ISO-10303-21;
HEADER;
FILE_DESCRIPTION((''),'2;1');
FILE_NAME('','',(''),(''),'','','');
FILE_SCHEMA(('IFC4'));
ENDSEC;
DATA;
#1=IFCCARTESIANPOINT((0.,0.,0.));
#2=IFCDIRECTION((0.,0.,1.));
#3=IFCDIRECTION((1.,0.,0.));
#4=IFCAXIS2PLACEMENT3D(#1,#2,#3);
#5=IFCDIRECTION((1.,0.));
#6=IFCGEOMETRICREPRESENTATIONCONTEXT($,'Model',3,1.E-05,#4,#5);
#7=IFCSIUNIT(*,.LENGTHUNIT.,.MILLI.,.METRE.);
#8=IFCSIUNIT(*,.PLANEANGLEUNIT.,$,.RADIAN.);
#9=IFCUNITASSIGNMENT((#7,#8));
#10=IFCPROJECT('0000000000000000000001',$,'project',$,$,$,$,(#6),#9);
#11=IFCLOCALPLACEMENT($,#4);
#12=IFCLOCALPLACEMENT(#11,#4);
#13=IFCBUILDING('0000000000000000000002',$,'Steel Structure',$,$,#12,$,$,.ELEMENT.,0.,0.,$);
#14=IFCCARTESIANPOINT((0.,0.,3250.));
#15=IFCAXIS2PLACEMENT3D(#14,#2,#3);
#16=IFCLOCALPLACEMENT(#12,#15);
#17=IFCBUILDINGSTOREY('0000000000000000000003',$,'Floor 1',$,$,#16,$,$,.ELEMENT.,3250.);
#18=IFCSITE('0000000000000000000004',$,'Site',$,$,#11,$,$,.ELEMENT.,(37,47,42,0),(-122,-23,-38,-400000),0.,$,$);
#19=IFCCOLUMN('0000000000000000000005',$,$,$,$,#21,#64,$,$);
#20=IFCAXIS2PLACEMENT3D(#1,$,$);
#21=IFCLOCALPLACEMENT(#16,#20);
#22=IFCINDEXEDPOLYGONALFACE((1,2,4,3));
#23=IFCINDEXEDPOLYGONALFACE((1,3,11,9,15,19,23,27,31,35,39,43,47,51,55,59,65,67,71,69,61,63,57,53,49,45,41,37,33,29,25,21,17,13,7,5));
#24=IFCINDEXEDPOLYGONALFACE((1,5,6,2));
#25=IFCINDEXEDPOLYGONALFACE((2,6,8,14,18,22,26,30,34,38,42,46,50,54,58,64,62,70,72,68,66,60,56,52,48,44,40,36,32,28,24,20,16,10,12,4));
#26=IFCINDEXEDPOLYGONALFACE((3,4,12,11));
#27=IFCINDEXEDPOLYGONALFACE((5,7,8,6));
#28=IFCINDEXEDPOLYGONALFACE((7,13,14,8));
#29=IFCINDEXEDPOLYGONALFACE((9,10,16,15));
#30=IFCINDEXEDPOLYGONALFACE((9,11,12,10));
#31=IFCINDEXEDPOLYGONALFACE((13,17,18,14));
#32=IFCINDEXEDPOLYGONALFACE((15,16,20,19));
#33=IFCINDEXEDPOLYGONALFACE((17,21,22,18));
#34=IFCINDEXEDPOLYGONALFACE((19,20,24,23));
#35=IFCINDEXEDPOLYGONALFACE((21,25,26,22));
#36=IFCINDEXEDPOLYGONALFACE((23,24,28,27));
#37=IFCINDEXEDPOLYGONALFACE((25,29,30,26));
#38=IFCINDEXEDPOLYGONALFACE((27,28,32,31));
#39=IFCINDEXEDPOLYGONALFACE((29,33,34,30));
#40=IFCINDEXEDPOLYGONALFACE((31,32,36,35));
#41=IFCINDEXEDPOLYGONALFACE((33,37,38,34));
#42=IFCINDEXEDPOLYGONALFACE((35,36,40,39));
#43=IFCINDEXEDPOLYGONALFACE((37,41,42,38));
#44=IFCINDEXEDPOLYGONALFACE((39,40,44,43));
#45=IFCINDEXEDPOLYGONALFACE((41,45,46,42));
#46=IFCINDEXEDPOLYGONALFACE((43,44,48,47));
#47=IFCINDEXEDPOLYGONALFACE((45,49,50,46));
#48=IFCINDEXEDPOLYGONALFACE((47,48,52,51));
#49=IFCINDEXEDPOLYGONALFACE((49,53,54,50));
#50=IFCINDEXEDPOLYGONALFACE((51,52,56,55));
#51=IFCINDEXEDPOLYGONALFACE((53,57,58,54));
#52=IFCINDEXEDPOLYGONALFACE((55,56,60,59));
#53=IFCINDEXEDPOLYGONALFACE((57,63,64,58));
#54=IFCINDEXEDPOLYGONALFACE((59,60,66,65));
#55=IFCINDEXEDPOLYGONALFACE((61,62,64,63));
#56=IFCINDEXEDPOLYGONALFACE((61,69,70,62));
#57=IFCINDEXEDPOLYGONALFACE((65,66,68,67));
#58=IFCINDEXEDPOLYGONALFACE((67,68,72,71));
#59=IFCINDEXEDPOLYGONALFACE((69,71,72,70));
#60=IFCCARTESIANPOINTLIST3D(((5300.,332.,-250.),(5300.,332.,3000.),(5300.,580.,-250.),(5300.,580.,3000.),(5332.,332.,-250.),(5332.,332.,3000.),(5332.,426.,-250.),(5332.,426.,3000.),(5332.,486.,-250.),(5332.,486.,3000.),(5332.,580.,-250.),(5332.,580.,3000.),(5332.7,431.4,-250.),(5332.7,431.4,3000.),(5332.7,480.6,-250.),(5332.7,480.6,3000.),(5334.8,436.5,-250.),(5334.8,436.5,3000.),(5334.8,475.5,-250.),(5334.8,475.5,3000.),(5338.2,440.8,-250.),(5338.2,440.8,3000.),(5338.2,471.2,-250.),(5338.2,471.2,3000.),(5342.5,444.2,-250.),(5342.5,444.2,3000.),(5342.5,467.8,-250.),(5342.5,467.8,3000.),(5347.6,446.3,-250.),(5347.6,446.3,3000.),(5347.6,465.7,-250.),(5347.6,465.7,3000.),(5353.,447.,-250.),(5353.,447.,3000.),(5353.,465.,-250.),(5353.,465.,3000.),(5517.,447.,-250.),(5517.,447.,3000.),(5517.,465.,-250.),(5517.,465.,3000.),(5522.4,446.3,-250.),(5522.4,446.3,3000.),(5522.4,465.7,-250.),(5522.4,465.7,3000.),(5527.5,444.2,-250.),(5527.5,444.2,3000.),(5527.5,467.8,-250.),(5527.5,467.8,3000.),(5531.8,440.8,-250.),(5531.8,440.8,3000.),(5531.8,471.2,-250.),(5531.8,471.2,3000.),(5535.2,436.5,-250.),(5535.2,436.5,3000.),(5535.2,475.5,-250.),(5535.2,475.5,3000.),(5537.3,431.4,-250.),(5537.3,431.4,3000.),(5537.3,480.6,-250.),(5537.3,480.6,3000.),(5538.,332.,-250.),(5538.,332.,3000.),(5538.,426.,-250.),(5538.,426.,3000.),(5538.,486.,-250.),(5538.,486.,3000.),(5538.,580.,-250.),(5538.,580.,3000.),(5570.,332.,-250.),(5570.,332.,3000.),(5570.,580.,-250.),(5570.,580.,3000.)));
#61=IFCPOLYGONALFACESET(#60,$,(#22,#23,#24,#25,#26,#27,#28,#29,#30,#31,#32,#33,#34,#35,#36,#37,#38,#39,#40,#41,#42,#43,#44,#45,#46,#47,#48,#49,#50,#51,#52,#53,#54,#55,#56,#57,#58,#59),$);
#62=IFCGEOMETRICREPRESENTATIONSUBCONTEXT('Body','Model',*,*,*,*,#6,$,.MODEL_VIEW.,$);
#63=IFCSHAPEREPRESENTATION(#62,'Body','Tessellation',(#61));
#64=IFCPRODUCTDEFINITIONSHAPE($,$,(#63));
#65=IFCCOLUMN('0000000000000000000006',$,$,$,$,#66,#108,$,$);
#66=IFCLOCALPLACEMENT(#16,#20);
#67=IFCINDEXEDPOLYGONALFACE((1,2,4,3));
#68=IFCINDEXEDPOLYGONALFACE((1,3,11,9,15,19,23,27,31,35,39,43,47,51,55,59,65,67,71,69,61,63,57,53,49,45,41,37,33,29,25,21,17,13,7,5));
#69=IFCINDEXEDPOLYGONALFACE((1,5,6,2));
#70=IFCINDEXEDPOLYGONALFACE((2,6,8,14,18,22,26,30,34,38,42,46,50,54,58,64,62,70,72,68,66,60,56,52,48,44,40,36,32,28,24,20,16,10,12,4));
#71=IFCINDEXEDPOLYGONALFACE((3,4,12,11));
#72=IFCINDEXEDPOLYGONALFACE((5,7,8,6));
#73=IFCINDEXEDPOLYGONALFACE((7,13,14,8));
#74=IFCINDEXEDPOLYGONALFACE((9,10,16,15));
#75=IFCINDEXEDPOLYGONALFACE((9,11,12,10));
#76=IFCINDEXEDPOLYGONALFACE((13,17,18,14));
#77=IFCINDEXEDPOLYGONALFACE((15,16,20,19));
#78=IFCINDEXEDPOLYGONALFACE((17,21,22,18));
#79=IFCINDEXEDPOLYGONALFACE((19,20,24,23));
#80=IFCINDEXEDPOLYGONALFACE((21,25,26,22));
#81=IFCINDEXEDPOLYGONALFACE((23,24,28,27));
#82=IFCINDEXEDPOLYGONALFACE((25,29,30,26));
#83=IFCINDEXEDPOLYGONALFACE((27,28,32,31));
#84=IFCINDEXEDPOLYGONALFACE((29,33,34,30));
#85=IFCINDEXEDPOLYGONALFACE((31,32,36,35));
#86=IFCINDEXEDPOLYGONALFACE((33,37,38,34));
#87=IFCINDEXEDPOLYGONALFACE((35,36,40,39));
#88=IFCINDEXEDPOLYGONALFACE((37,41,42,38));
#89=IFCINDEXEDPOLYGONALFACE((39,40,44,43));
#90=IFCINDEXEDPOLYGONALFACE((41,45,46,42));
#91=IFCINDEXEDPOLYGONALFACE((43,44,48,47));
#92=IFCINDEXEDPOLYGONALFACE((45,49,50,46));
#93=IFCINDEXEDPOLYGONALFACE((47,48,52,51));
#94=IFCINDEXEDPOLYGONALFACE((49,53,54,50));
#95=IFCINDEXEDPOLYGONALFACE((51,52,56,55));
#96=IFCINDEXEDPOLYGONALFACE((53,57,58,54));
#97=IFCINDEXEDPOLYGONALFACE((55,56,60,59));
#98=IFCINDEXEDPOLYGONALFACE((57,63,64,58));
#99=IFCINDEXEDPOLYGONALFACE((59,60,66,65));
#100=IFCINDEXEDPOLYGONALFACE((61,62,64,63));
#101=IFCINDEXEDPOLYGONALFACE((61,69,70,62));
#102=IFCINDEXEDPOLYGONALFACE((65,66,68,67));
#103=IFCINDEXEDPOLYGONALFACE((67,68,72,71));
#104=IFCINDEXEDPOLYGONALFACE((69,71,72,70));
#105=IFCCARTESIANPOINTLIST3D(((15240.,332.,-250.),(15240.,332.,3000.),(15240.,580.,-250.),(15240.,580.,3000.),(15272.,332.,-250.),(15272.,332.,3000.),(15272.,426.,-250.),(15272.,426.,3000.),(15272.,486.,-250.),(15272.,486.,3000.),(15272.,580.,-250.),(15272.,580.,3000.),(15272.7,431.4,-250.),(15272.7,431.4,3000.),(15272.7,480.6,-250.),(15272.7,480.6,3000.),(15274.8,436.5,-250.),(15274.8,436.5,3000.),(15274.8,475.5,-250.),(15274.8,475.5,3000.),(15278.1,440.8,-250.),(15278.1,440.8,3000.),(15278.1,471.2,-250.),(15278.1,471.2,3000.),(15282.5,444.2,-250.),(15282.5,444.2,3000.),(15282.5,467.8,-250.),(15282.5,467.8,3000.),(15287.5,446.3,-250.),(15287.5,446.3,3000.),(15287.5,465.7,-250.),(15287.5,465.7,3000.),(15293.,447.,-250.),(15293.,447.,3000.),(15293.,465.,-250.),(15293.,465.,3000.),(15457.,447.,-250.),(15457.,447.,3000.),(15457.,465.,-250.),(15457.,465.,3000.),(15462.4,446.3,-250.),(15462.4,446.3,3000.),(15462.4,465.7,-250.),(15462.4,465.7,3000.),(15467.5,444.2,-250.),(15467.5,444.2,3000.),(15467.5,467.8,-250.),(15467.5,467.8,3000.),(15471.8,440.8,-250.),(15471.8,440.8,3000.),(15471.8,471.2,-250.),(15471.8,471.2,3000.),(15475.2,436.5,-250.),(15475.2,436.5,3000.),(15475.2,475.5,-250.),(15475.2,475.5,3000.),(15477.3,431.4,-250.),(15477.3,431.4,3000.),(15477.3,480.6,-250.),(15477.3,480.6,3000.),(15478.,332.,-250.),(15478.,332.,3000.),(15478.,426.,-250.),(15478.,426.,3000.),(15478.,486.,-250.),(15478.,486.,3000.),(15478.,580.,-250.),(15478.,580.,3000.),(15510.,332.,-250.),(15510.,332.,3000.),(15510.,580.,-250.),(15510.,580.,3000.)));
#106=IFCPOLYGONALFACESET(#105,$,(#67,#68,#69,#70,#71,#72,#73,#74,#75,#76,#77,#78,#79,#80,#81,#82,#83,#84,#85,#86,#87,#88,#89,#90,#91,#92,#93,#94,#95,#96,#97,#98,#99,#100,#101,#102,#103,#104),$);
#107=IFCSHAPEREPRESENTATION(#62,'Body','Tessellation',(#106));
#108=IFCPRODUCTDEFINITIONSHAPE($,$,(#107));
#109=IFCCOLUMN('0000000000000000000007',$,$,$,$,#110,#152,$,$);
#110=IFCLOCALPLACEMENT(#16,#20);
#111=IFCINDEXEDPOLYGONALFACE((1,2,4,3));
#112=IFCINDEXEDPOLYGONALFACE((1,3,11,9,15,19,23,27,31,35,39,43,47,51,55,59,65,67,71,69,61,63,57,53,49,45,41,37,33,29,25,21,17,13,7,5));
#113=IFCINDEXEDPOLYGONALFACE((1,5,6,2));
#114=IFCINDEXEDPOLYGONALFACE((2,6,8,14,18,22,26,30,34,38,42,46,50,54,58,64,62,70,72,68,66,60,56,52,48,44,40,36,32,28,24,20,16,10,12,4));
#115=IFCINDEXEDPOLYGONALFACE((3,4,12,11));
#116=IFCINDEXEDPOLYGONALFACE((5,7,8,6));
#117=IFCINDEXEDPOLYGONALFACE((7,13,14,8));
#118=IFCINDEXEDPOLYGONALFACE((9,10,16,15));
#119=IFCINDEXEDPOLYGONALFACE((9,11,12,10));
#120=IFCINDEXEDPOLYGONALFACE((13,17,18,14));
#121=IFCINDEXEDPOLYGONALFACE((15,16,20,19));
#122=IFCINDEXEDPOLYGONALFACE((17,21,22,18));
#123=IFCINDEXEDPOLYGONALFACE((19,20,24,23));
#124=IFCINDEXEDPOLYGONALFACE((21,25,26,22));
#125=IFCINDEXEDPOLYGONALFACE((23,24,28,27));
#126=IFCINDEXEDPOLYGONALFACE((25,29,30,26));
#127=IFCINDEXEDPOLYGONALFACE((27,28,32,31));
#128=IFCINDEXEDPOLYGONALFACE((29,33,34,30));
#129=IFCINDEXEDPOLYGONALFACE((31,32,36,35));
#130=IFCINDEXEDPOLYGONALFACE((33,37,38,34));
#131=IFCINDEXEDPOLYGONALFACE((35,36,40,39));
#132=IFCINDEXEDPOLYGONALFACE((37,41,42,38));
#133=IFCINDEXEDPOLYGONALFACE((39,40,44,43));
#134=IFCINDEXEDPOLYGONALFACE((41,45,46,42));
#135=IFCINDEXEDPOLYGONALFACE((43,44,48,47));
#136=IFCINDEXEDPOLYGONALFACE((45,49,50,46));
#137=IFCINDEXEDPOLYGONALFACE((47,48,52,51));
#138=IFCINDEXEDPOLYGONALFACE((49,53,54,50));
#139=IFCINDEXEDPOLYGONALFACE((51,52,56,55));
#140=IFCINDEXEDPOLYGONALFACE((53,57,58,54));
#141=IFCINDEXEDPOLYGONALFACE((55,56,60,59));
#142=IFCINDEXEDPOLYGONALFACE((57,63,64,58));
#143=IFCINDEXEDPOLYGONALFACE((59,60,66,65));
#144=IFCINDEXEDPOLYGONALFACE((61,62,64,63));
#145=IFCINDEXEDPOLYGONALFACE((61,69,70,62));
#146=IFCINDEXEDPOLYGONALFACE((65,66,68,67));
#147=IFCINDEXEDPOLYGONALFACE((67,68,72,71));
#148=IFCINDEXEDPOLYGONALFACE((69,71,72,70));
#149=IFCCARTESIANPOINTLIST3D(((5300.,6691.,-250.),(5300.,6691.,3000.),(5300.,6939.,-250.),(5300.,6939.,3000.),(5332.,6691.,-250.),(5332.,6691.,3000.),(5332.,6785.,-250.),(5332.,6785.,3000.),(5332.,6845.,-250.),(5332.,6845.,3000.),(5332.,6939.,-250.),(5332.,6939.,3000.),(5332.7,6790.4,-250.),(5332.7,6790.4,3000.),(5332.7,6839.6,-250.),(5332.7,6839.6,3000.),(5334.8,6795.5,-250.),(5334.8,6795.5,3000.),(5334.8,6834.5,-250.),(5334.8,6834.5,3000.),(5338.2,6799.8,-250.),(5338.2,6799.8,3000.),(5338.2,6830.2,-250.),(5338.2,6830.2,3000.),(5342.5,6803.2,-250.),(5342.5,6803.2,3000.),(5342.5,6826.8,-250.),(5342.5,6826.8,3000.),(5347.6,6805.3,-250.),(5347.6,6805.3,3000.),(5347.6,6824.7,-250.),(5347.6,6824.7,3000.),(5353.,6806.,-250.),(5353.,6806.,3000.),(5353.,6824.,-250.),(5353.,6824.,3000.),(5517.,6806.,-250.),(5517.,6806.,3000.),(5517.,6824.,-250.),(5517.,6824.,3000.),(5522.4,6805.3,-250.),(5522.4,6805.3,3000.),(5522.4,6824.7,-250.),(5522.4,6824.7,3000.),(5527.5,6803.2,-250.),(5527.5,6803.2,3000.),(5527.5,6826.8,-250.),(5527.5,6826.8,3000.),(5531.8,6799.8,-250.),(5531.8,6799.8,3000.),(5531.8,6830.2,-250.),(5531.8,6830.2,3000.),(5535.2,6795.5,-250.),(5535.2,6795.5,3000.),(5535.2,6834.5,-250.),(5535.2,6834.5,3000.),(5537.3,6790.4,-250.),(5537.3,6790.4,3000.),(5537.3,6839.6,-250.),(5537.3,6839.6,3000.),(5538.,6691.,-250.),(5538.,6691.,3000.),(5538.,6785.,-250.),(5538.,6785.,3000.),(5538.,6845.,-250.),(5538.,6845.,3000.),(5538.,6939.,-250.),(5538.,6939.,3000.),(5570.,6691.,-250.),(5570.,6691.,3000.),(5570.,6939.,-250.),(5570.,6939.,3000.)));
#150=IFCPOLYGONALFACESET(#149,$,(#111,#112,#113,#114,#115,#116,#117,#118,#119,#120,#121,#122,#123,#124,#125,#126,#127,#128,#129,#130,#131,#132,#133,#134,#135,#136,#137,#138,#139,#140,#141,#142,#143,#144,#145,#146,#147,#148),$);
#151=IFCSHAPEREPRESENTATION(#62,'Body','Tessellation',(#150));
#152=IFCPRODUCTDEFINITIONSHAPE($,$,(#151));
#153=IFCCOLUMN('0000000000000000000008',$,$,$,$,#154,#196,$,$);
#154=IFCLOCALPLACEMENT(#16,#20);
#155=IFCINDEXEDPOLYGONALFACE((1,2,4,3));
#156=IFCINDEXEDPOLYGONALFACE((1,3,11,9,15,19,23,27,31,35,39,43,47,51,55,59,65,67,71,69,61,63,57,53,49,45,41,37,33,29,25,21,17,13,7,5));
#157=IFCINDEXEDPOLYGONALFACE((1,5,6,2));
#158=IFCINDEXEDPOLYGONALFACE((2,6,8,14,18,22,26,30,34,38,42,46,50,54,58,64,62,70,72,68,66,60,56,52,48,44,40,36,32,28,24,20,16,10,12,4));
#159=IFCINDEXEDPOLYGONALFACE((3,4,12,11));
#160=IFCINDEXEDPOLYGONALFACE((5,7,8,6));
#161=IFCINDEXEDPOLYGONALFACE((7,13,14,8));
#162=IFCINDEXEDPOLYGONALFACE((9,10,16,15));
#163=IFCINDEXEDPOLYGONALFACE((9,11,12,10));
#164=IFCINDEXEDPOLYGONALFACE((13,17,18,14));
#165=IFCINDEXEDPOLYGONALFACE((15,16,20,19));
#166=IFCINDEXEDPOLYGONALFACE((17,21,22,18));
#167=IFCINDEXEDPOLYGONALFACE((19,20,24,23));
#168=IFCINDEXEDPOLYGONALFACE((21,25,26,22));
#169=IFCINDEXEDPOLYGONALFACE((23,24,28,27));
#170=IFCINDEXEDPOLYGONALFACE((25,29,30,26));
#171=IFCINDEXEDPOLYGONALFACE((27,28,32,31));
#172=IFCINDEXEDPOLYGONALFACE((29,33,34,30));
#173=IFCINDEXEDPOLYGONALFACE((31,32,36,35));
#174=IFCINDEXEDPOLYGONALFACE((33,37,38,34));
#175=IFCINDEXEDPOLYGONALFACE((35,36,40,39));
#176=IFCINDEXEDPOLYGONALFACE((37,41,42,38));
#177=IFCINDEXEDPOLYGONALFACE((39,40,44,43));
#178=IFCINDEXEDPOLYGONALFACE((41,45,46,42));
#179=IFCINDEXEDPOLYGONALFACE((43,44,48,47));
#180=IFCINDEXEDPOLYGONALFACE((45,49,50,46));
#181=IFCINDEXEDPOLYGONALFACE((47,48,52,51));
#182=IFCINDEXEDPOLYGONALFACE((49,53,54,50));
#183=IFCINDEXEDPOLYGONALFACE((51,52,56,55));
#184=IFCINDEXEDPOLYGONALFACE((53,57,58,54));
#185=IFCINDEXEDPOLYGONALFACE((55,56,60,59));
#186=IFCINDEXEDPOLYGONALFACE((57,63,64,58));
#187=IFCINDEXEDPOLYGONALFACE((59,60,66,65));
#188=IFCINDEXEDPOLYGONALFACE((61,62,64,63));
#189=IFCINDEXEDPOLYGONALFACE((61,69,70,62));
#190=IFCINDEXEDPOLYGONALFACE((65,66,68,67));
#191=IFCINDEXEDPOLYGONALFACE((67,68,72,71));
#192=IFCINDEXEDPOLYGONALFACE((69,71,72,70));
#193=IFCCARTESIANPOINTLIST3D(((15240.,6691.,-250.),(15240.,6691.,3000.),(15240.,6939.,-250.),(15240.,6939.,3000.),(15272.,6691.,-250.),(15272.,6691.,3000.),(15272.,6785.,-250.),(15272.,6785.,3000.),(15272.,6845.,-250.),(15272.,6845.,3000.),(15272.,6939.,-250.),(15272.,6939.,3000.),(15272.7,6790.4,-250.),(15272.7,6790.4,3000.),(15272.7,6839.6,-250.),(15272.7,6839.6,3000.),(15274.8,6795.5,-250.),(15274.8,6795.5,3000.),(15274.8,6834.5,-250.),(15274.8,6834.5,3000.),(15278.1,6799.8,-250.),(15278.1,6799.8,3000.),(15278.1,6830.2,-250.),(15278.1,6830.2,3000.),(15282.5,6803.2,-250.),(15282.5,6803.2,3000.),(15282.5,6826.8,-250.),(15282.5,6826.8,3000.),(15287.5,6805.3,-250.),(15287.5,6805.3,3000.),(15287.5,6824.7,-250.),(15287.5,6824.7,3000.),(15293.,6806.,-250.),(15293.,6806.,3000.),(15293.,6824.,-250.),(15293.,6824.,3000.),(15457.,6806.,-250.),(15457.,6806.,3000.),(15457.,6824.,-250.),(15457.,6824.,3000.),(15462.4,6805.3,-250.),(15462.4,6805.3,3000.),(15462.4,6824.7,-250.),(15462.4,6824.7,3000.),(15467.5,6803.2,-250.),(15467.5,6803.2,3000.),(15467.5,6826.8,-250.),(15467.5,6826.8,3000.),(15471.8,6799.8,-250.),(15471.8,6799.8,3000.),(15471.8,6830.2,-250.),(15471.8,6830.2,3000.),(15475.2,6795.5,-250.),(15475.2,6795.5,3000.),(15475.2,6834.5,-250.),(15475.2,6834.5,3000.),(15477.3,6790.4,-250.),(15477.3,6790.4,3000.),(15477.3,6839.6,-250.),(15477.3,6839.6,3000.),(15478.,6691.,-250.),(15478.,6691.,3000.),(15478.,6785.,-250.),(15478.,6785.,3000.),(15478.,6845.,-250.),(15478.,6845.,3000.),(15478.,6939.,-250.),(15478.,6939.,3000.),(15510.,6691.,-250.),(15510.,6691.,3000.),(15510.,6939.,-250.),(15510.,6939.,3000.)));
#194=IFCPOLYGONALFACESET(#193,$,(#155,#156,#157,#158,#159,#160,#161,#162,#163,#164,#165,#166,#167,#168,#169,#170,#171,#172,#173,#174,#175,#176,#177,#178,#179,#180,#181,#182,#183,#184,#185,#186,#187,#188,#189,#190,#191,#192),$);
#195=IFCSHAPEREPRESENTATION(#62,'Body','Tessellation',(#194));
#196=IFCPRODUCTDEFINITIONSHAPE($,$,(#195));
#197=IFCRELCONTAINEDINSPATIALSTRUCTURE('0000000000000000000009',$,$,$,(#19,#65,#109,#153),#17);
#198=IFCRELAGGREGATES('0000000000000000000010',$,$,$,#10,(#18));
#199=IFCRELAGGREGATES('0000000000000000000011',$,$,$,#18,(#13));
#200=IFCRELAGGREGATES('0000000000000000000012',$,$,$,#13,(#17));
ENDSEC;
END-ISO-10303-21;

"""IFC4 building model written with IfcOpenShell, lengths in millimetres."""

from ifc_helpers import new_model, si_unit, direction, frame, origin_with_axes, origin_2d_with_axis, place, context, subcontext, project, spatial, i_section, extrude, element, save


model = new_model("IFC4")

# Units and contexts
model_context = context("Model", 3, precision=1e-05, world=origin_with_axes(), true_north=direction((1.0, 0.0)))
body_context = subcontext(model_context, "Body", "Model", "MODEL_VIEW")
ifc_project = project(units=[si_unit("LENGTHUNIT", "METRE", prefix="MILLI"), si_unit("PLANEANGLEUNIT", "RADIAN")], contexts=[model_context])

# Site, building, storey
site_placement = place(None, origin_with_axes())
site = spatial("IfcSite", under=ifc_project, at=site_placement, Name="Site", CompositionType="ELEMENT", RefLatitude=(37, 47, 42, 0), RefLongitude=(-122, -23, -38, -400000), RefElevation=0.0)
building_placement = place(site_placement, origin_with_axes())
building = spatial("IfcBuilding", under=site, at=building_placement, Name="Steel Structure", CompositionType="ELEMENT", ElevationOfRefHeight=0.0, ElevationOfTerrain=0.0)
storey_placement = place(building_placement, frame((0.0, 0.0, 3250.0), z_axis=(0.0, 0.0, 1.0), x_axis=(1.0, 0.0, 0.0)))
storey = spatial("IfcBuildingStorey", under=building, at=storey_placement, Name="Floor 1", CompositionType="ELEMENT", Elevation=3250.0)

# Columns
column_1_placement = place(storey_placement, frame((5435.0, 456.0, -250.0), z_axis=(0.0, 0.0, 1.0), x_axis=(0.0, 1.0, 0.0)))
element("IfcColumn", 1, at=column_1_placement, inside=storey, context=body_context, shape_type="SweptSolid", body=[
    extrude(i_section(OverallWidth=248.0, OverallDepth=270.0, WebThickness=18.0, FlangeThickness=32.0, FilletRadius=21.0, at=origin_2d_with_axis()), origin_with_axes(), (0.0, 0.0, 1.0), 3250.0),
])
column_2_placement = place(storey_placement, frame((15375.0, 456.0, -250.0), z_axis=(0.0, 0.0, 1.0), x_axis=(0.0, 1.0, 0.0)))
element("IfcColumn", 2, at=column_2_placement, inside=storey, context=body_context, shape_type="SweptSolid", body=[
    extrude(i_section(OverallWidth=248.0, OverallDepth=270.0, WebThickness=18.0, FlangeThickness=32.0, FilletRadius=21.0, at=origin_2d_with_axis()), origin_with_axes(), (0.0, 0.0, 1.0), 3250.0),
])
column_3_placement = place(storey_placement, frame((5435.0, 6815.0, -250.0), z_axis=(0.0, 0.0, 1.0), x_axis=(0.0, -1.0, 0.0)))
element("IfcColumn", 3, at=column_3_placement, inside=storey, context=body_context, shape_type="SweptSolid", body=[
    extrude(i_section(OverallWidth=248.0, OverallDepth=270.0, WebThickness=18.0, FlangeThickness=32.0, FilletRadius=21.0, at=origin_2d_with_axis()), origin_with_axes(), (0.0, 0.0, 1.0), 3250.0),
])
for number, where, z_axis, x_axis in (
    (4, (15375.0, 6815.0, -250.0), (0.0, 0.0, 1.0), (0.0, -1.0, 0.0)),
):
    element("IfcColumn", number, at=place(storey_placement, frame(where, z_axis=z_axis, x_axis=x_axis)), inside=storey, context=body_context, shape_type="SweptSolid", body=[
        extrude(i_section(OverallWidth=248.0, OverallDepth=270.0, WebThickness=18.0, FlangeThickness=32.0, FilletRadius=21.0, at=origin_2d_with_axis()), origin_with_axes(), (0.0, 0.0, 1.0), 3250.0),
    ])

save(model, "model.ifc")
